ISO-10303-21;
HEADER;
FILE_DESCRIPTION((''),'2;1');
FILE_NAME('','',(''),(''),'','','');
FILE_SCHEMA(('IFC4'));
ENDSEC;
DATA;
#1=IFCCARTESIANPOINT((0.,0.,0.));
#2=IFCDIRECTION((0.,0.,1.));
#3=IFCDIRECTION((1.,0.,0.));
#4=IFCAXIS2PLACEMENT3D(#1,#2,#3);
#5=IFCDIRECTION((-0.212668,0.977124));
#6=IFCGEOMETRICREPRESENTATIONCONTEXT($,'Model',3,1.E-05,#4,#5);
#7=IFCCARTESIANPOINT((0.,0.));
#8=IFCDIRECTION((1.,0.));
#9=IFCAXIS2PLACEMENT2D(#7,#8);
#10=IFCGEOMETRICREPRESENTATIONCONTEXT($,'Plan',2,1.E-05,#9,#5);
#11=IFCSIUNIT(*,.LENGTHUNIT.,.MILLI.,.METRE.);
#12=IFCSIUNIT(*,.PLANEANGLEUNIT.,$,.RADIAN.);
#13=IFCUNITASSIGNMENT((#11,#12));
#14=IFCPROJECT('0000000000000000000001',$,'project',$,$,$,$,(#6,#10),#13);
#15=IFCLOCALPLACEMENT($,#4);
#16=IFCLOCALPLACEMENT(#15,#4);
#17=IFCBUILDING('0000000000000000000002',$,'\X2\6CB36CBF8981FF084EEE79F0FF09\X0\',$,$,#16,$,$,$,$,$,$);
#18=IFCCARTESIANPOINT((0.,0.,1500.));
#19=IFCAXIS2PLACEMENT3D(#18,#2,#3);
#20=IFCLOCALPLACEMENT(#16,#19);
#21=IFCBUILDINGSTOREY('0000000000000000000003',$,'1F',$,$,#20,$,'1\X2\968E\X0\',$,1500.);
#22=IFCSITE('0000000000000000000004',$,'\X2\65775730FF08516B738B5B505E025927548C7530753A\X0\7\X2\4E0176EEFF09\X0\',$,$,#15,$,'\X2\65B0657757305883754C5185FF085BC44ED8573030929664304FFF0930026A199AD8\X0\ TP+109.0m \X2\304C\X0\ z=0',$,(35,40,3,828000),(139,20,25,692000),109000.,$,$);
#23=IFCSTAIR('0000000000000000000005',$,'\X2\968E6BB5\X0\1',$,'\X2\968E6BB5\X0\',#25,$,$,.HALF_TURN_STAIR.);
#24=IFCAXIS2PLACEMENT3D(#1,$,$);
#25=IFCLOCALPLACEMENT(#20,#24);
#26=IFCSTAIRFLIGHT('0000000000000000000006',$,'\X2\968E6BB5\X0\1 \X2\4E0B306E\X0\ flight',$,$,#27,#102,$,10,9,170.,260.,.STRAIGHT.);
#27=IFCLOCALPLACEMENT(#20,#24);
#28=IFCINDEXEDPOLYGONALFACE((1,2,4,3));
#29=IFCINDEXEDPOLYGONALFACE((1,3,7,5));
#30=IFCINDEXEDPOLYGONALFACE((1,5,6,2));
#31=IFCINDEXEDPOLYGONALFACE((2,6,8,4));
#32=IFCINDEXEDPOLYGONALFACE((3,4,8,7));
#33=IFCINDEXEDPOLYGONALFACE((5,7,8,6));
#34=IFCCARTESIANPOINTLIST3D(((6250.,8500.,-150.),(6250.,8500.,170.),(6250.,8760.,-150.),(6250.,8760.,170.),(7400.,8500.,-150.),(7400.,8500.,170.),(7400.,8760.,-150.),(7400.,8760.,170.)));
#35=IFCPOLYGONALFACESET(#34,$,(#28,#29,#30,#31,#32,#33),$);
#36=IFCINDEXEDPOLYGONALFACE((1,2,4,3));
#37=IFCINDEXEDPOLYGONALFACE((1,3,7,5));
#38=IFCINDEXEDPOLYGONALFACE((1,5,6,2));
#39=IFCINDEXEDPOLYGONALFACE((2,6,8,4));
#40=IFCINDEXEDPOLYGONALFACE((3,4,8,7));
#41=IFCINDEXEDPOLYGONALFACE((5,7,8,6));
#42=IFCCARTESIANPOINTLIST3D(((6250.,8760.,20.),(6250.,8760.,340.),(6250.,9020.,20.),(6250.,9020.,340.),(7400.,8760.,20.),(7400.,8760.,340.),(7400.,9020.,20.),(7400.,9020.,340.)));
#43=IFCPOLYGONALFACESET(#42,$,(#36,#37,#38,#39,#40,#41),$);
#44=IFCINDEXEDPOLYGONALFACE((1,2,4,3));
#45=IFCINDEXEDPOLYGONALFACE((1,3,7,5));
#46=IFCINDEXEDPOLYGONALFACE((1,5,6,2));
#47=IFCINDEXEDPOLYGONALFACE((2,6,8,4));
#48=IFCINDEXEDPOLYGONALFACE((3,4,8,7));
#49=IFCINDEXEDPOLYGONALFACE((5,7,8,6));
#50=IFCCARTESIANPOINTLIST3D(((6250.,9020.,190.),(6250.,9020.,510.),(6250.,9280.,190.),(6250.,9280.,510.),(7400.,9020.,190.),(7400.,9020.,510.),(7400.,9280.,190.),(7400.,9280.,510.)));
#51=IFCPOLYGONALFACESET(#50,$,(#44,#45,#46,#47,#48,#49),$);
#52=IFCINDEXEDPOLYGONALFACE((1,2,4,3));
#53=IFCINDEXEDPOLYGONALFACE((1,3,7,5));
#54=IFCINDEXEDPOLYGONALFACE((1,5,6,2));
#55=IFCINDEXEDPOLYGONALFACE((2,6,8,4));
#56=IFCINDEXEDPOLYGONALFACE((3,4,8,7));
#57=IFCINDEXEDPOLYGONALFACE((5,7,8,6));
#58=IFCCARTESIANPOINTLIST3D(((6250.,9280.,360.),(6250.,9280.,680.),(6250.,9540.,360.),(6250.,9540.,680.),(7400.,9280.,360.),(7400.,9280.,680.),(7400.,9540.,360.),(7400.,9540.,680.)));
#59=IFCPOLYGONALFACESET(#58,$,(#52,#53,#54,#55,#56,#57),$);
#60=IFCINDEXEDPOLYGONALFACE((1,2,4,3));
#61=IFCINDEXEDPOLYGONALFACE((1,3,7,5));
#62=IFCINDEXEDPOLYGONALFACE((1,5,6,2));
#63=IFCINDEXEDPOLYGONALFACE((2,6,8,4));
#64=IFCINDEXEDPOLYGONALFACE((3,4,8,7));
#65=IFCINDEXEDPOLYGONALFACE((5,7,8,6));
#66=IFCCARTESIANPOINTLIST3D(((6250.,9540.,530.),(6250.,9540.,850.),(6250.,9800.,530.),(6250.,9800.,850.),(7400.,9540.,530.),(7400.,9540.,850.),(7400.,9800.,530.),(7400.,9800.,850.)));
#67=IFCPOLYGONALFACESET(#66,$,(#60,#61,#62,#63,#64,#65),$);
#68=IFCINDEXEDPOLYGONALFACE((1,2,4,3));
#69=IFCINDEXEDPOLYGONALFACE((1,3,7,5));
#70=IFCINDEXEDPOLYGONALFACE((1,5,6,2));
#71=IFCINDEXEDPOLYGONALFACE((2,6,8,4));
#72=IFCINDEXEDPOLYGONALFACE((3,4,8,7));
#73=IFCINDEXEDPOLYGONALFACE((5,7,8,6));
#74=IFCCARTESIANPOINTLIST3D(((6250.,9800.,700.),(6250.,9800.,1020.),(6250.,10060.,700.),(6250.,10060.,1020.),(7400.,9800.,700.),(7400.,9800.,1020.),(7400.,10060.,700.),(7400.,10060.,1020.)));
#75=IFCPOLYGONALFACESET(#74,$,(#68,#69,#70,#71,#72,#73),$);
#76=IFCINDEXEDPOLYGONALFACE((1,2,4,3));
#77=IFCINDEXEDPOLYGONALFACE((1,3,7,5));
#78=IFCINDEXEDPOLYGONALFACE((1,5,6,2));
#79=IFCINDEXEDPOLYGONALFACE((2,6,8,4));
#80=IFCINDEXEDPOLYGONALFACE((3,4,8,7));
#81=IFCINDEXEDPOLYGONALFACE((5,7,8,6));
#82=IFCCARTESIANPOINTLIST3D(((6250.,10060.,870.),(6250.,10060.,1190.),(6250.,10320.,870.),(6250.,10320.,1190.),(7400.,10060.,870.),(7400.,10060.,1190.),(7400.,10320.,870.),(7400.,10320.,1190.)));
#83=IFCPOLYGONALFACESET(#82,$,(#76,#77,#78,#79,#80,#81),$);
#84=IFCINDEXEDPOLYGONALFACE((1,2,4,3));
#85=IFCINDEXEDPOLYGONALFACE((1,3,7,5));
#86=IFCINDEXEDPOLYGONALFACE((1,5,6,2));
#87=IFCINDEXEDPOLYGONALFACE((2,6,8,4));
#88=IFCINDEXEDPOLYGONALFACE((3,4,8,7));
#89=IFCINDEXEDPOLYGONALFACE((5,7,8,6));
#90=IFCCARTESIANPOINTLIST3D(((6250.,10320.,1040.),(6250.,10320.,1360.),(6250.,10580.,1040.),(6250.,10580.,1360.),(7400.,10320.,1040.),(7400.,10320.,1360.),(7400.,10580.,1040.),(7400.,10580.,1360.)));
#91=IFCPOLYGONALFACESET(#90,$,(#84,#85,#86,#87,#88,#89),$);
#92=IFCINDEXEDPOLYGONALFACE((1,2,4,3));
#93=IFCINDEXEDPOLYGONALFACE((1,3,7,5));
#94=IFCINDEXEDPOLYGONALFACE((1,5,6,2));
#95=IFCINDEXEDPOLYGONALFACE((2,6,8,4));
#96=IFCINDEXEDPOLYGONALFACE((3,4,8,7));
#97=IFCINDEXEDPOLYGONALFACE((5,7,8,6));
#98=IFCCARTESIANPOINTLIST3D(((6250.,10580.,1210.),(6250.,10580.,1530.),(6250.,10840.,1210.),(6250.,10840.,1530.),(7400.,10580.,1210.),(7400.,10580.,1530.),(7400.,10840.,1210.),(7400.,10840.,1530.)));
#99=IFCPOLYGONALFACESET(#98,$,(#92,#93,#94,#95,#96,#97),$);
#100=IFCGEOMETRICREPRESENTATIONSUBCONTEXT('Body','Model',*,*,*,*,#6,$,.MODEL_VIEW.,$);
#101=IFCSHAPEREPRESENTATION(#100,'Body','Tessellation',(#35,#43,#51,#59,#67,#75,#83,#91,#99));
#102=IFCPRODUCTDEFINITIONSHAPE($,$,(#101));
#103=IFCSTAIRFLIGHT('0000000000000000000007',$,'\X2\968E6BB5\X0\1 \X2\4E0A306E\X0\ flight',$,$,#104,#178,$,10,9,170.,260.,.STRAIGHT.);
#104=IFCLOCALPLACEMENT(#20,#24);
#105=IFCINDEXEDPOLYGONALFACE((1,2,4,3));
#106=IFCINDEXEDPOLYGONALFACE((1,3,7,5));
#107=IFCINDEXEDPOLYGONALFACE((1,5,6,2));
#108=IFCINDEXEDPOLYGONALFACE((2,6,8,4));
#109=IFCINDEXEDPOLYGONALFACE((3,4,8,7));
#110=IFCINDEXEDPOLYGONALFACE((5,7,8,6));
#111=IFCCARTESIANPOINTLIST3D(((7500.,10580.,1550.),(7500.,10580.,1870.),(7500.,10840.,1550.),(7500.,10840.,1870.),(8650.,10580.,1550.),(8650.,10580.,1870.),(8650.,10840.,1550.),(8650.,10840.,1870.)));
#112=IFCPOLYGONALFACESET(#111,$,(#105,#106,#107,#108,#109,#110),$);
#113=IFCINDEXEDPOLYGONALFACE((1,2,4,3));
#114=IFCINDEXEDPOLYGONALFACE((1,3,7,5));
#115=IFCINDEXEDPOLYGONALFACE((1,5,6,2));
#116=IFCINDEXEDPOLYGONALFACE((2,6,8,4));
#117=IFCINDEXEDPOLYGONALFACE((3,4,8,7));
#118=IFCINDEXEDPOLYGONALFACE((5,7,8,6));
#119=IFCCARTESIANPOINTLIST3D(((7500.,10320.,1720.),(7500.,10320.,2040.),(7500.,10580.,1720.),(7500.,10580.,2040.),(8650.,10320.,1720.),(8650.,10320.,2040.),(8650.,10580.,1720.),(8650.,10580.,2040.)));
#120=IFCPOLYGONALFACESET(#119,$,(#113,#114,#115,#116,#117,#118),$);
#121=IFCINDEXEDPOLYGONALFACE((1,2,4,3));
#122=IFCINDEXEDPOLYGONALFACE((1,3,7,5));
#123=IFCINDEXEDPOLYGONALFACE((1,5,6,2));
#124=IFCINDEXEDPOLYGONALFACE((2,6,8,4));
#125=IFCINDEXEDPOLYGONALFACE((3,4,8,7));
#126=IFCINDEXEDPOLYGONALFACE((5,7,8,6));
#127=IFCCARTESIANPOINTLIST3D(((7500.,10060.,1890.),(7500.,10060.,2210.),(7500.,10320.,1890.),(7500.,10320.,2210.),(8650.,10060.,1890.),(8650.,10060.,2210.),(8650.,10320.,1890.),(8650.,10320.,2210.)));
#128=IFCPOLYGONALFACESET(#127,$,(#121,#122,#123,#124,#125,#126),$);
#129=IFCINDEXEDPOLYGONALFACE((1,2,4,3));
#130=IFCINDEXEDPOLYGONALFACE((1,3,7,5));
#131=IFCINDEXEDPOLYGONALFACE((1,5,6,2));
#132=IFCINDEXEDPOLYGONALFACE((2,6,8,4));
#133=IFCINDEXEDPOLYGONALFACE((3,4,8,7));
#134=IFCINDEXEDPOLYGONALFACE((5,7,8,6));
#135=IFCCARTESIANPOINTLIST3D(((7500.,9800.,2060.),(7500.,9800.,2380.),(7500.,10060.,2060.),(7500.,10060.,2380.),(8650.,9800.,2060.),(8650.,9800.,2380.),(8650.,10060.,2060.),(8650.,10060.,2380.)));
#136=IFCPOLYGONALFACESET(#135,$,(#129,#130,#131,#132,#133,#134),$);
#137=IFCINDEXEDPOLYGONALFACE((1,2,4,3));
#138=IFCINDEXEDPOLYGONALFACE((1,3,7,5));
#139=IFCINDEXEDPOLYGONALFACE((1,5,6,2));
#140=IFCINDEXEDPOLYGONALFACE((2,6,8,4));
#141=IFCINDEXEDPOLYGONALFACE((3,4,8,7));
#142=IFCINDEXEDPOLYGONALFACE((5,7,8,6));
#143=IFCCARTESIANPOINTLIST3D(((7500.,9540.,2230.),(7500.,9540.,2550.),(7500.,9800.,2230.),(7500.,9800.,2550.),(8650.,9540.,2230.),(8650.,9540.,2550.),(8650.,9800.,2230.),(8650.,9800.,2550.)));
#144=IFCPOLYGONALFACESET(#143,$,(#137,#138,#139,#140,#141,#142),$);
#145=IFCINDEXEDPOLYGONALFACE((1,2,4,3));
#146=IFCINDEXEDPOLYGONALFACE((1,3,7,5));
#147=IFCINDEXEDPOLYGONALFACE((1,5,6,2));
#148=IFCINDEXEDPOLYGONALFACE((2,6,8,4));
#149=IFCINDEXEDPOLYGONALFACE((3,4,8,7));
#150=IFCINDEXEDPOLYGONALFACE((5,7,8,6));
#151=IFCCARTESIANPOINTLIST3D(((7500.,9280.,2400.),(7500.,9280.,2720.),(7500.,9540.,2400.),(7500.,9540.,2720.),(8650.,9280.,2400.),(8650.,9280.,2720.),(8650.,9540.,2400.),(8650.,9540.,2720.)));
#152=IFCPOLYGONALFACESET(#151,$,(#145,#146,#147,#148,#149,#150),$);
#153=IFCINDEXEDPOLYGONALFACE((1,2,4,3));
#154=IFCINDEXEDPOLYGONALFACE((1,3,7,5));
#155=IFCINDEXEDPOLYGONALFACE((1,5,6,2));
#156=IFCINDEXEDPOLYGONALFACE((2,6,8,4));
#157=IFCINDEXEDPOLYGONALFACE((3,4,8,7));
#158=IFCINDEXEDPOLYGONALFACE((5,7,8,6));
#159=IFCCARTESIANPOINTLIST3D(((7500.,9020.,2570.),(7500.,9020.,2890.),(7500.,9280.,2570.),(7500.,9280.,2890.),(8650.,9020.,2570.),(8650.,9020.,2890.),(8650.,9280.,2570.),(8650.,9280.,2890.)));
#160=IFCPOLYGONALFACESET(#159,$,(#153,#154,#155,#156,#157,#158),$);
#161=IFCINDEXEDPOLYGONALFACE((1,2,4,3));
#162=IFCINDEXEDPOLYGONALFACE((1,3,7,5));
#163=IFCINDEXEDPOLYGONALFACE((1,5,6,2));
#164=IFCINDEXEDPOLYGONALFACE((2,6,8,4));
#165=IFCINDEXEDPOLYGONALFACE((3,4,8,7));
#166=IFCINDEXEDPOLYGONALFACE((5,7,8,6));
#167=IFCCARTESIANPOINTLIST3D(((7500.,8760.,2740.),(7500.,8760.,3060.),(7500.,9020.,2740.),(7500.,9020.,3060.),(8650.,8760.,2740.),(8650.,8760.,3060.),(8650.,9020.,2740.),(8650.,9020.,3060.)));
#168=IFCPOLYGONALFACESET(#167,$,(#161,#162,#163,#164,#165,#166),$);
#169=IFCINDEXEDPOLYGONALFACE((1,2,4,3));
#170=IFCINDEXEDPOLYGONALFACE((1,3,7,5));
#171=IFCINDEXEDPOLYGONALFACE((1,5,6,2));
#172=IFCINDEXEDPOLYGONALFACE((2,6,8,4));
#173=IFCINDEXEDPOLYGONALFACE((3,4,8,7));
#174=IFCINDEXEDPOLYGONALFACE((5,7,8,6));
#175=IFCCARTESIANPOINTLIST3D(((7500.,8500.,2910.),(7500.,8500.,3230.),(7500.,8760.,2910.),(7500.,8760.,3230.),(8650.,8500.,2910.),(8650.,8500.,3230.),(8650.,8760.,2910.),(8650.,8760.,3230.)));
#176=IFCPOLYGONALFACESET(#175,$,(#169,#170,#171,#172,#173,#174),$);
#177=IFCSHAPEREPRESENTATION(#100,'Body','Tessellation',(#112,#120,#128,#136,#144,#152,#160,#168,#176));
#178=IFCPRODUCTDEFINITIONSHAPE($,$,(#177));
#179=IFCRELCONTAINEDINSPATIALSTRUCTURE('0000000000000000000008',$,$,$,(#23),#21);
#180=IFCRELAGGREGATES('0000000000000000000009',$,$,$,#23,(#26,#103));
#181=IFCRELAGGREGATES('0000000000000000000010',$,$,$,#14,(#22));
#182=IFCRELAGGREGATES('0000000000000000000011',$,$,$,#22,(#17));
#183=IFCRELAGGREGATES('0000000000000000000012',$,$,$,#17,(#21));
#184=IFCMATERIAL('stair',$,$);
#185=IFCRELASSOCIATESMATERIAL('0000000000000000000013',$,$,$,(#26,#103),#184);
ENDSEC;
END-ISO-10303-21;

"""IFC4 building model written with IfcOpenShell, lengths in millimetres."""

from ifc_helpers import new_model, si_unit, direction, frame, frame_2d, origin_with_axes, origin_2d_with_axis, place, context, subcontext, project, spatial, rectangle, extrude, material, element, aggregate, save


model = new_model("IFC4")

# Units and contexts
model_context = context("Model", 3, precision=1e-05, world=origin_with_axes(), true_north=direction((-0.212668, 0.977124)))
plan_context = context("Plan", 2, precision=1e-05, world=origin_2d_with_axis(), true_north=direction((-0.212668, 0.977124)))
body_context = subcontext(model_context, "Body", "Model", "MODEL_VIEW")
ifc_project = project(units=[si_unit("LENGTHUNIT", "METRE", prefix="MILLI"), si_unit("PLANEANGLEUNIT", "RADIAN")], contexts=[model_context, plan_context])

# Site, building, storey
site_placement = place(None, origin_with_axes())
site = spatial("IfcSite", under=ifc_project, at=site_placement, Name="敷地（八王子市大和田町7丁目）", LongName="新敷地境界内（寄付地を除く）。標高 TP+109.0m が z=0", RefLatitude=(35, 40, 3, 828000), RefLongitude=(139, 20, 25, 692000), RefElevation=109000.0)
building_placement = place(site_placement, origin_with_axes())
building = spatial("IfcBuilding", under=site, at=building_placement, Name="河沿要（仮称）")
storey_placement = place(building_placement, frame((0.0, 0.0, 1500.0), z_axis=(0.0, 0.0, 1.0), x_axis=(1.0, 0.0, 0.0)))
storey = spatial("IfcBuildingStorey", under=building, at=storey_placement, Name="1F", LongName="1階", Elevation=1500.0)

# Stair
stair_1_placement = place(storey_placement, origin_with_axes())
stair_1 = element("IfcStair", 1, at=stair_1_placement, inside=storey, Name="階段1", ObjectType="階段", PredefinedType="HALF_TURN_STAIR")
ifc_material_1 = material(Name="stair")

# Stair flights
stair_flight_1_placement = place(stair_1_placement, origin_with_axes())
stair_flight_1 = element("IfcStairFlight", 2, at=stair_flight_1_placement, material=ifc_material_1, Name="階段1 下の flight", NumberOfRisers=10, NumberOfTreads=9, PredefinedType="STRAIGHT", RiserHeight=170.0, TreadLength=260.0, context=body_context, shape_type="SweptSolid", body=[
    extrude(rectangle(XDim=1150.0, YDim=260.0, at=frame_2d((6825.0, 8630.0))), frame((0.0, 0.0, -150.0)), (0.0, 0.0, 1.0), 320.0),
    extrude(rectangle(XDim=1150.0, YDim=260.0, at=frame_2d((6825.0, 8890.0))), frame((0.0, 0.0, 20.0)), (0.0, 0.0, 1.0), 320.0),
    extrude(rectangle(XDim=1150.0, YDim=260.0, at=frame_2d((6825.0, 9150.0))), frame((0.0, 0.0, 190.0)), (0.0, 0.0, 1.0), 320.0),
    extrude(rectangle(XDim=1150.0, YDim=260.0, at=frame_2d((6825.0, 9410.0))), frame((0.0, 0.0, 360.0)), (0.0, 0.0, 1.0), 320.0),
    extrude(rectangle(XDim=1150.0, YDim=260.0, at=frame_2d((6825.0, 9670.0))), frame((0.0, 0.0, 530.0)), (0.0, 0.0, 1.0), 320.0),
    extrude(rectangle(XDim=1150.0, YDim=260.0, at=frame_2d((6825.0, 9930.0))), frame((0.0, 0.0, 700.0)), (0.0, 0.0, 1.0), 320.0),
    extrude(rectangle(XDim=1150.0, YDim=260.0, at=frame_2d((6825.0, 10190.0))), frame((0.0, 0.0, 870.0)), (0.0, 0.0, 1.0), 320.0),
    extrude(rectangle(XDim=1150.0, YDim=260.0, at=frame_2d((6825.0, 10450.0))), frame((0.0, 0.0, 1040.0)), (0.0, 0.0, 1.0), 320.0),
    extrude(rectangle(XDim=1150.0, YDim=260.0, at=frame_2d((6825.0, 10710.0))), frame((0.0, 0.0, 1210.0)), (0.0, 0.0, 1.0), 320.0),
])
stair_flight_2_placement = place(stair_1_placement, origin_with_axes())
stair_flight_2 = element("IfcStairFlight", 3, at=stair_flight_2_placement, material=ifc_material_1, Name="階段1 上の flight", NumberOfRisers=10, NumberOfTreads=9, PredefinedType="STRAIGHT", RiserHeight=170.0, TreadLength=260.0, context=body_context, shape_type="SweptSolid", body=[
    extrude(rectangle(XDim=1150.0, YDim=260.0, at=frame_2d((8075.0, 10710.0))), frame((0.0, 0.0, 1550.0)), (0.0, 0.0, 1.0), 320.0),
    extrude(rectangle(XDim=1150.0, YDim=260.0, at=frame_2d((8075.0, 10450.0))), frame((0.0, 0.0, 1720.0)), (0.0, 0.0, 1.0), 320.0),
    extrude(rectangle(XDim=1150.0, YDim=260.0, at=frame_2d((8075.0, 10190.0))), frame((0.0, 0.0, 1890.0)), (0.0, 0.0, 1.0), 320.0),
    extrude(rectangle(XDim=1150.0, YDim=260.0, at=frame_2d((8075.0, 9930.0))), frame((0.0, 0.0, 2060.0)), (0.0, 0.0, 1.0), 320.0),
    extrude(rectangle(XDim=1150.0, YDim=260.0, at=frame_2d((8075.0, 9670.0))), frame((0.0, 0.0, 2230.0)), (0.0, 0.0, 1.0), 320.0),
    extrude(rectangle(XDim=1150.0, YDim=260.0, at=frame_2d((8075.0, 9410.0))), frame((0.0, 0.0, 2400.0)), (0.0, 0.0, 1.0), 320.0),
    extrude(rectangle(XDim=1150.0, YDim=260.0, at=frame_2d((8075.0, 9150.0))), frame((0.0, 0.0, 2570.0)), (0.0, 0.0, 1.0), 320.0),
    extrude(rectangle(XDim=1150.0, YDim=260.0, at=frame_2d((8075.0, 8890.0))), frame((0.0, 0.0, 2740.0)), (0.0, 0.0, 1.0), 320.0),
    extrude(rectangle(XDim=1150.0, YDim=260.0, at=frame_2d((8075.0, 8630.0))), frame((0.0, 0.0, 2910.0)), (0.0, 0.0, 1.0), 320.0),
])
aggregate(stair_1, [stair_flight_1, stair_flight_2])

save(model, "model.ifc")
